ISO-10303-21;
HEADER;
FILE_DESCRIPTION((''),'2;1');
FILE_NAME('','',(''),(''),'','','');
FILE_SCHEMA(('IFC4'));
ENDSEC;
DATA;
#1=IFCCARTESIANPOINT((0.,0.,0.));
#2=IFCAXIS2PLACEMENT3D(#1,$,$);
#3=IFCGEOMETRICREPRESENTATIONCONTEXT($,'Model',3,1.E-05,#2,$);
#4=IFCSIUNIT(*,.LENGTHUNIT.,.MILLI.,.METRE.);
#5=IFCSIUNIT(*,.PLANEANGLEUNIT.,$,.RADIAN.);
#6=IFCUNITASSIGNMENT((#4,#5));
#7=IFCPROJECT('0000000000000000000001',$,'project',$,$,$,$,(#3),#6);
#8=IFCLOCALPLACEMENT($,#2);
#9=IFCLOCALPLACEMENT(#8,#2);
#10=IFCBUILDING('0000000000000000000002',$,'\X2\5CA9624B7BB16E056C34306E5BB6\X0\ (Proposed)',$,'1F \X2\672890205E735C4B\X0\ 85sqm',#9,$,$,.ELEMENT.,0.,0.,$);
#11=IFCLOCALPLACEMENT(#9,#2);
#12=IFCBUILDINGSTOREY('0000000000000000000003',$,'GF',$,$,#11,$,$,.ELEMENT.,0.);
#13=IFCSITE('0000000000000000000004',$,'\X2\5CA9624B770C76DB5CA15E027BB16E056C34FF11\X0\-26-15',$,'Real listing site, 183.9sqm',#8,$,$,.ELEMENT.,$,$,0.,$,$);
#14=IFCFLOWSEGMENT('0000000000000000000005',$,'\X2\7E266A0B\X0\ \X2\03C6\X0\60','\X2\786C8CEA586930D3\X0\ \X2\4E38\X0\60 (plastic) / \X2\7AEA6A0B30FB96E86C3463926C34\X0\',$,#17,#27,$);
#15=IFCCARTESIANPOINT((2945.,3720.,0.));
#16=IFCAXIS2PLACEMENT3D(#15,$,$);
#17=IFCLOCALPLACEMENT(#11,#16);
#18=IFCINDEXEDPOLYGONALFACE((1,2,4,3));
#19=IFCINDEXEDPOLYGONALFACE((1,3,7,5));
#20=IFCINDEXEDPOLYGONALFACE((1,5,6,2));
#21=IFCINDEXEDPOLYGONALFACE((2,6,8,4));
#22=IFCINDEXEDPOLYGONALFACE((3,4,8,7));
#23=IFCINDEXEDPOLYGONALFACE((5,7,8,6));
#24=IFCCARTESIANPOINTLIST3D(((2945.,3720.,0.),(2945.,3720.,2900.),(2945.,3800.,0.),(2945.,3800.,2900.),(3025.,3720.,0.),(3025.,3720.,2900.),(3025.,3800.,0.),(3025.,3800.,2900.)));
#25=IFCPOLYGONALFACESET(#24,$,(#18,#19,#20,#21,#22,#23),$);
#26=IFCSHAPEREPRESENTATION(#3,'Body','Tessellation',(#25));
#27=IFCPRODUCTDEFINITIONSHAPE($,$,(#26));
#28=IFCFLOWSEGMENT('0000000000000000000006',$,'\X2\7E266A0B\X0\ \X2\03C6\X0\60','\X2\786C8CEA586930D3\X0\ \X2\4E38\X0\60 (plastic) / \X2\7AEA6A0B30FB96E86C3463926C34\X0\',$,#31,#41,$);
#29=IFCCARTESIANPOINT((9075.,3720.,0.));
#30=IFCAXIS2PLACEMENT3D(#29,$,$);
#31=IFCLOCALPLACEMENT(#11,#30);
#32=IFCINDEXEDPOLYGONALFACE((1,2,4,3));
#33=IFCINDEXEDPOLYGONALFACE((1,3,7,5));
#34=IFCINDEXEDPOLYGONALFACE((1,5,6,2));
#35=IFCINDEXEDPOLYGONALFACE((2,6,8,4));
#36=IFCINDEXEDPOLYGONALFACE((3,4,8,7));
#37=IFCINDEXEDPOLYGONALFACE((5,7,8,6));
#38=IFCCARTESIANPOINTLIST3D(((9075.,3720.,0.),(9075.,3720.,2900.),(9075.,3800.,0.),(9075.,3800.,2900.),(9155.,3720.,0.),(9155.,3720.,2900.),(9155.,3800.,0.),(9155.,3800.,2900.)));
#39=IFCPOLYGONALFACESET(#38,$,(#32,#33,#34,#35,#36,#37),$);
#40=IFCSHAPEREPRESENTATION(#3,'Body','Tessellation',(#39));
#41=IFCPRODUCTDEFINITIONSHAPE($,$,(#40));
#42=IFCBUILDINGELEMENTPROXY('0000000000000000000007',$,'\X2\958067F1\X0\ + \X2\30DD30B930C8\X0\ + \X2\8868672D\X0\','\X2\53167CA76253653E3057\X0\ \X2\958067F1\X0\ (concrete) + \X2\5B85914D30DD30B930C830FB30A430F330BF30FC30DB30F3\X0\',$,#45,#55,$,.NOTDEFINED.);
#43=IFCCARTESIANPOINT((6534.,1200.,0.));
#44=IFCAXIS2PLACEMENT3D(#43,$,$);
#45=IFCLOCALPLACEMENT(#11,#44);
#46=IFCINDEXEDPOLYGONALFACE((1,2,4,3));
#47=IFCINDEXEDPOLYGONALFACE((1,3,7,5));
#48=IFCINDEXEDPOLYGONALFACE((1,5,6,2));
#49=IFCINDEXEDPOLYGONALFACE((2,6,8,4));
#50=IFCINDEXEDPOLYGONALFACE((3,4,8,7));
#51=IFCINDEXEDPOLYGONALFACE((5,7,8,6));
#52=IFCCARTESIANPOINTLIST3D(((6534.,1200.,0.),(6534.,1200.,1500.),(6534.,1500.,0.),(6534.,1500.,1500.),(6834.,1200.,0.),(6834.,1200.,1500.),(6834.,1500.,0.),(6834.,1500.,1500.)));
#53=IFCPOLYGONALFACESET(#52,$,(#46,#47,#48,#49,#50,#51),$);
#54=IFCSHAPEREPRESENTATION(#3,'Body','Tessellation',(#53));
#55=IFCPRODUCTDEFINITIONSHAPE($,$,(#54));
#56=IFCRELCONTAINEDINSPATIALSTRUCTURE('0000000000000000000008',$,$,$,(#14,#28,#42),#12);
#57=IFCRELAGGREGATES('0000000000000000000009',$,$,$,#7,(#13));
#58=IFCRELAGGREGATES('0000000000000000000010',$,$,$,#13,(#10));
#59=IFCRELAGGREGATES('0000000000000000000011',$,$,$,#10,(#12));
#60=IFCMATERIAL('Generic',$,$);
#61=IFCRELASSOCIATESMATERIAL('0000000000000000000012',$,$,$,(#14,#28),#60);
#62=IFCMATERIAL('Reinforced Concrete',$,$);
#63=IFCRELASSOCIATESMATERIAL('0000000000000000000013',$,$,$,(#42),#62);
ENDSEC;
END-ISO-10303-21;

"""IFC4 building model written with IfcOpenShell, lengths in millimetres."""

from ifc_helpers import new_model, si_unit, frame, frame_2d, origin, place, context, project, spatial, rectangle, extrude, material, element, save


model = new_model("IFC4")

# Units and contexts
model_context = context("Model", 3, precision=1e-05, world=origin())
ifc_project = project(units=[si_unit("LENGTHUNIT", "METRE", prefix="MILLI"), si_unit("PLANEANGLEUNIT", "RADIAN")], contexts=[model_context])

# Site, building, storey
site_placement = place(None, origin())
site = spatial("IfcSite", under=ifc_project, at=site_placement, Name="岩手県盛岡市箱清水１-26-15", ObjectType="Real listing site, 183.9sqm", CompositionType="ELEMENT", RefElevation=0.0)
building_placement = place(site_placement, origin())
building = spatial("IfcBuilding", under=site, at=building_placement, Name="岩手箱清水の家 (Proposed)", ObjectType="1F 木造平屋 85sqm", CompositionType="ELEMENT", ElevationOfRefHeight=0.0, ElevationOfTerrain=0.0)
storey_placement = place(building_placement, origin())
storey = spatial("IfcBuildingStorey", under=building, at=storey_placement, Name="GF", CompositionType="ELEMENT", Elevation=0.0)

# Shared definitions
ifc_material_1 = material(Name="Reinforced Concrete")

# Flow segments
ifc_material_2 = material(Name="Generic")
flow_segment_1_placement = place(storey_placement, frame((2945.0, 3720.0, 0.0)))
element("IfcFlowSegment", 1, at=flow_segment_1_placement, inside=storey, material=ifc_material_2, Name="縦樋 φ60", Description="硬質塩ビ 丸60 (plastic) / 竪樋・雨水排水", context=model_context, shape_type="SweptSolid", body=[
    extrude(rectangle(XDim=80.0, YDim=80.0, at=frame_2d((40.0, 40.0))), frame((2945.0, 3720.0, 0.0)), (0.0, 0.0, 1.0), 2900.0),
])
flow_segment_2_placement = place(storey_placement, frame((9075.0, 3720.0, 0.0)))
element("IfcFlowSegment", 2, at=flow_segment_2_placement, inside=storey, material=ifc_material_2, Name="縦樋 φ60", Description="硬質塩ビ 丸60 (plastic) / 竪樋・雨水排水", context=model_context, shape_type="SweptSolid", body=[
    extrude(rectangle(XDim=80.0, YDim=80.0, at=frame_2d((40.0, 40.0))), frame((9075.0, 3720.0, 0.0)), (0.0, 0.0, 1.0), 2900.0),
])

# Building element proxy
proxy_placement = place(storey_placement, frame((6534.0, 1200.0, 0.0)))
element("IfcBuildingElementProxy", 3, at=proxy_placement, inside=storey, material=ifc_material_1, Name="門柱 + ポスト + 表札", Description="化粧打放し 門柱 (concrete) + 宅配ポスト・インターホン", PredefinedType="NOTDEFINED", context=model_context, shape_type="SweptSolid", body=[
    extrude(rectangle(XDim=300.0, YDim=300.0, at=frame_2d((150.0, 150.0))), frame((6534.0, 1200.0, 0.0)), (0.0, 0.0, 1.0), 1500.0),
])

save(model, "model.ifc")
